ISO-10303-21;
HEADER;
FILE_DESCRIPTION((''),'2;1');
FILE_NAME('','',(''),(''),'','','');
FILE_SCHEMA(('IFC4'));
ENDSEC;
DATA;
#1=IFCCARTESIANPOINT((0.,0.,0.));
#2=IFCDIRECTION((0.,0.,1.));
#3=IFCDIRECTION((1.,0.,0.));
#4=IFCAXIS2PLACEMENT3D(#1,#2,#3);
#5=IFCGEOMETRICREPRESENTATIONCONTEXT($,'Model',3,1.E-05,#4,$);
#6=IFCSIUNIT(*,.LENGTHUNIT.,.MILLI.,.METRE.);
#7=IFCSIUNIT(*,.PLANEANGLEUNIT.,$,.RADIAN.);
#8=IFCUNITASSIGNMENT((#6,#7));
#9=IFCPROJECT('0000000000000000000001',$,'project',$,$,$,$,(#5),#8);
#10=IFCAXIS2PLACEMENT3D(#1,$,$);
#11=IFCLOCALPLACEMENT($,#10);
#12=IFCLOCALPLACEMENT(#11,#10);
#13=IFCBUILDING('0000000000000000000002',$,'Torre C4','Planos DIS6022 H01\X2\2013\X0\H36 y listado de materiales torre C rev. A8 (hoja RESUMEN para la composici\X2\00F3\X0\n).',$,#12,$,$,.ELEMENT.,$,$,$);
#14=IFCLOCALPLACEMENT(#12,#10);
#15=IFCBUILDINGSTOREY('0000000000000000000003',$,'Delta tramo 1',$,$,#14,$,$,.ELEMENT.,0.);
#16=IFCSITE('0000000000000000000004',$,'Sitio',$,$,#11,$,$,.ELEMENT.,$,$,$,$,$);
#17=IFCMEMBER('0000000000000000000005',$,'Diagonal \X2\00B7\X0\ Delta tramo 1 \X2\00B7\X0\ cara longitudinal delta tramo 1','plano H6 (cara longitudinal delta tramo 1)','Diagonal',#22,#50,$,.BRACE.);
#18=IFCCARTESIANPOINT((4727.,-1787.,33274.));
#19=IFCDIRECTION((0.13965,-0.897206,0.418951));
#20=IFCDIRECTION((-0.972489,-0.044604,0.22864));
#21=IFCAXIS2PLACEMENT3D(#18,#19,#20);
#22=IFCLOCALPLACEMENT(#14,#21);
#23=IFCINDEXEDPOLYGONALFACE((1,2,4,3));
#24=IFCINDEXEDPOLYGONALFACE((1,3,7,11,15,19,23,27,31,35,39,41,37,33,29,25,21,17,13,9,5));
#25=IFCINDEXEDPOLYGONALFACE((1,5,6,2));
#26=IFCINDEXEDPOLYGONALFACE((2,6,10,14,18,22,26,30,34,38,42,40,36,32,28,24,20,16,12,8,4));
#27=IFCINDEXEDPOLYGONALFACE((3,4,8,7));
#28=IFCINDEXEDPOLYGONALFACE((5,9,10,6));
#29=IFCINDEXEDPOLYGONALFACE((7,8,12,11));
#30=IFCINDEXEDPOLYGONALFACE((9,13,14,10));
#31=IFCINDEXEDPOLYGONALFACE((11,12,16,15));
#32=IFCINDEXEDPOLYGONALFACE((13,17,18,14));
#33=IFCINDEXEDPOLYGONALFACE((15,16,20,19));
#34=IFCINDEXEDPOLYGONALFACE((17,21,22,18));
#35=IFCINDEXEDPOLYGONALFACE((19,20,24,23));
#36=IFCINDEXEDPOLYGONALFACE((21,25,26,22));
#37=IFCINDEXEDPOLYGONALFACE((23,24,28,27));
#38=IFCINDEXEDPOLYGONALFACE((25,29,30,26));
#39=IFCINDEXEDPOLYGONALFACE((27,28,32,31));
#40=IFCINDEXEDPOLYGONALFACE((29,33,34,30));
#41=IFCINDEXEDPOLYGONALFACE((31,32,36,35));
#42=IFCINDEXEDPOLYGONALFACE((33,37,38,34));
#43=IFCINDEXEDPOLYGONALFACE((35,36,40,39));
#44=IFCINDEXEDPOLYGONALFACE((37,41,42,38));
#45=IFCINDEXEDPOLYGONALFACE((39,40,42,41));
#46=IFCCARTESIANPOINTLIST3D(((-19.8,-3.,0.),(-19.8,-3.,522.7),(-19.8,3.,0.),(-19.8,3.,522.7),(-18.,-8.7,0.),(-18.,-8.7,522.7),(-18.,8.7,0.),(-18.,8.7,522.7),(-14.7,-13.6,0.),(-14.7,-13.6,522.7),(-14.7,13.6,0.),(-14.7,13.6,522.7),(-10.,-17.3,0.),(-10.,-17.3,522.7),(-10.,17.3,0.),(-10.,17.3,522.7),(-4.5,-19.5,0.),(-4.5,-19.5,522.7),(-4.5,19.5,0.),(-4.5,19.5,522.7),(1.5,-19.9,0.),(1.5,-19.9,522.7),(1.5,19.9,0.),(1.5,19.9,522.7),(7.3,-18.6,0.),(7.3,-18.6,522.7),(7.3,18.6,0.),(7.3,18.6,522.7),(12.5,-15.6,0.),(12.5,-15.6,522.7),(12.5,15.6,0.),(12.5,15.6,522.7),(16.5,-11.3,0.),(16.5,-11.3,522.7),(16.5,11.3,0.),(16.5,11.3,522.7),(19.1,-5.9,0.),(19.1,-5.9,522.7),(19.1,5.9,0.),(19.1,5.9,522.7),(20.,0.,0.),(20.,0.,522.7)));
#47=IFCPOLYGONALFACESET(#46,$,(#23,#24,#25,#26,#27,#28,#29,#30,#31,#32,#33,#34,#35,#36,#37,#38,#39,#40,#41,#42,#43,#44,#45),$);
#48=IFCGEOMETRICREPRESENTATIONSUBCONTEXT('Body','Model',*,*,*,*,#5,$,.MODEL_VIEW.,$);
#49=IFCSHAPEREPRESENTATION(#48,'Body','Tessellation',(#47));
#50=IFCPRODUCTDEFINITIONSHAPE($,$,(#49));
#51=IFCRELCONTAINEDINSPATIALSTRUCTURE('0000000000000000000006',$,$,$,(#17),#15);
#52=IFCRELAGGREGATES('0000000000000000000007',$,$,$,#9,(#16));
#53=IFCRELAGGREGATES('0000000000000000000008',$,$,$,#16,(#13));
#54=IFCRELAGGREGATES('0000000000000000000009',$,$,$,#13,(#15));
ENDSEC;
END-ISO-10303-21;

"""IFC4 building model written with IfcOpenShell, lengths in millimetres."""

from ifc_helpers import new_model, si_unit, frame, origin, origin_with_axes, place, context, subcontext, project, spatial, circle, extrude, element, save


model = new_model("IFC4")

# Units and contexts
model_context = context("Model", 3, precision=1e-05, world=origin_with_axes())
body_context = subcontext(model_context, "Body", "Model", "MODEL_VIEW")
ifc_project = project(units=[si_unit("LENGTHUNIT", "METRE", prefix="MILLI"), si_unit("PLANEANGLEUNIT", "RADIAN")], contexts=[model_context])

# Site, building, storey
site_placement = place(None, origin())
site = spatial("IfcSite", under=ifc_project, at=site_placement, Name="Sitio", CompositionType="ELEMENT")
building_placement = place(site_placement, origin())
building = spatial("IfcBuilding", under=site, at=building_placement, Name="Torre C4", Description="Planos DIS6022 H01–H36 y listado de materiales torre C rev. A8 (hoja RESUMEN para la composición).", CompositionType="ELEMENT")
storey_placement = place(building_placement, origin())
storey = spatial("IfcBuildingStorey", under=building, at=storey_placement, Name="Delta tramo 1", CompositionType="ELEMENT", Elevation=0.0)

# Member
member_1_placement = place(storey_placement, frame((4727.0, -1787.0, 33274.0), z_axis=(0.13965, -0.897206, 0.418951), x_axis=(-0.972489, -0.044604, 0.22864)))
element("IfcMember", 1, at=member_1_placement, inside=storey, Name="Diagonal · Delta tramo 1 · cara longitudinal delta tramo 1", Description="plano H6 (cara longitudinal delta tramo 1)", ObjectType="Diagonal", PredefinedType="BRACE", context=body_context, shape_type="SweptSolid", body=[
    extrude(circle(Radius=20.0), None, (0.0, 0.0, 1.0), 522.7),
])

save(model, "model.ifc")
